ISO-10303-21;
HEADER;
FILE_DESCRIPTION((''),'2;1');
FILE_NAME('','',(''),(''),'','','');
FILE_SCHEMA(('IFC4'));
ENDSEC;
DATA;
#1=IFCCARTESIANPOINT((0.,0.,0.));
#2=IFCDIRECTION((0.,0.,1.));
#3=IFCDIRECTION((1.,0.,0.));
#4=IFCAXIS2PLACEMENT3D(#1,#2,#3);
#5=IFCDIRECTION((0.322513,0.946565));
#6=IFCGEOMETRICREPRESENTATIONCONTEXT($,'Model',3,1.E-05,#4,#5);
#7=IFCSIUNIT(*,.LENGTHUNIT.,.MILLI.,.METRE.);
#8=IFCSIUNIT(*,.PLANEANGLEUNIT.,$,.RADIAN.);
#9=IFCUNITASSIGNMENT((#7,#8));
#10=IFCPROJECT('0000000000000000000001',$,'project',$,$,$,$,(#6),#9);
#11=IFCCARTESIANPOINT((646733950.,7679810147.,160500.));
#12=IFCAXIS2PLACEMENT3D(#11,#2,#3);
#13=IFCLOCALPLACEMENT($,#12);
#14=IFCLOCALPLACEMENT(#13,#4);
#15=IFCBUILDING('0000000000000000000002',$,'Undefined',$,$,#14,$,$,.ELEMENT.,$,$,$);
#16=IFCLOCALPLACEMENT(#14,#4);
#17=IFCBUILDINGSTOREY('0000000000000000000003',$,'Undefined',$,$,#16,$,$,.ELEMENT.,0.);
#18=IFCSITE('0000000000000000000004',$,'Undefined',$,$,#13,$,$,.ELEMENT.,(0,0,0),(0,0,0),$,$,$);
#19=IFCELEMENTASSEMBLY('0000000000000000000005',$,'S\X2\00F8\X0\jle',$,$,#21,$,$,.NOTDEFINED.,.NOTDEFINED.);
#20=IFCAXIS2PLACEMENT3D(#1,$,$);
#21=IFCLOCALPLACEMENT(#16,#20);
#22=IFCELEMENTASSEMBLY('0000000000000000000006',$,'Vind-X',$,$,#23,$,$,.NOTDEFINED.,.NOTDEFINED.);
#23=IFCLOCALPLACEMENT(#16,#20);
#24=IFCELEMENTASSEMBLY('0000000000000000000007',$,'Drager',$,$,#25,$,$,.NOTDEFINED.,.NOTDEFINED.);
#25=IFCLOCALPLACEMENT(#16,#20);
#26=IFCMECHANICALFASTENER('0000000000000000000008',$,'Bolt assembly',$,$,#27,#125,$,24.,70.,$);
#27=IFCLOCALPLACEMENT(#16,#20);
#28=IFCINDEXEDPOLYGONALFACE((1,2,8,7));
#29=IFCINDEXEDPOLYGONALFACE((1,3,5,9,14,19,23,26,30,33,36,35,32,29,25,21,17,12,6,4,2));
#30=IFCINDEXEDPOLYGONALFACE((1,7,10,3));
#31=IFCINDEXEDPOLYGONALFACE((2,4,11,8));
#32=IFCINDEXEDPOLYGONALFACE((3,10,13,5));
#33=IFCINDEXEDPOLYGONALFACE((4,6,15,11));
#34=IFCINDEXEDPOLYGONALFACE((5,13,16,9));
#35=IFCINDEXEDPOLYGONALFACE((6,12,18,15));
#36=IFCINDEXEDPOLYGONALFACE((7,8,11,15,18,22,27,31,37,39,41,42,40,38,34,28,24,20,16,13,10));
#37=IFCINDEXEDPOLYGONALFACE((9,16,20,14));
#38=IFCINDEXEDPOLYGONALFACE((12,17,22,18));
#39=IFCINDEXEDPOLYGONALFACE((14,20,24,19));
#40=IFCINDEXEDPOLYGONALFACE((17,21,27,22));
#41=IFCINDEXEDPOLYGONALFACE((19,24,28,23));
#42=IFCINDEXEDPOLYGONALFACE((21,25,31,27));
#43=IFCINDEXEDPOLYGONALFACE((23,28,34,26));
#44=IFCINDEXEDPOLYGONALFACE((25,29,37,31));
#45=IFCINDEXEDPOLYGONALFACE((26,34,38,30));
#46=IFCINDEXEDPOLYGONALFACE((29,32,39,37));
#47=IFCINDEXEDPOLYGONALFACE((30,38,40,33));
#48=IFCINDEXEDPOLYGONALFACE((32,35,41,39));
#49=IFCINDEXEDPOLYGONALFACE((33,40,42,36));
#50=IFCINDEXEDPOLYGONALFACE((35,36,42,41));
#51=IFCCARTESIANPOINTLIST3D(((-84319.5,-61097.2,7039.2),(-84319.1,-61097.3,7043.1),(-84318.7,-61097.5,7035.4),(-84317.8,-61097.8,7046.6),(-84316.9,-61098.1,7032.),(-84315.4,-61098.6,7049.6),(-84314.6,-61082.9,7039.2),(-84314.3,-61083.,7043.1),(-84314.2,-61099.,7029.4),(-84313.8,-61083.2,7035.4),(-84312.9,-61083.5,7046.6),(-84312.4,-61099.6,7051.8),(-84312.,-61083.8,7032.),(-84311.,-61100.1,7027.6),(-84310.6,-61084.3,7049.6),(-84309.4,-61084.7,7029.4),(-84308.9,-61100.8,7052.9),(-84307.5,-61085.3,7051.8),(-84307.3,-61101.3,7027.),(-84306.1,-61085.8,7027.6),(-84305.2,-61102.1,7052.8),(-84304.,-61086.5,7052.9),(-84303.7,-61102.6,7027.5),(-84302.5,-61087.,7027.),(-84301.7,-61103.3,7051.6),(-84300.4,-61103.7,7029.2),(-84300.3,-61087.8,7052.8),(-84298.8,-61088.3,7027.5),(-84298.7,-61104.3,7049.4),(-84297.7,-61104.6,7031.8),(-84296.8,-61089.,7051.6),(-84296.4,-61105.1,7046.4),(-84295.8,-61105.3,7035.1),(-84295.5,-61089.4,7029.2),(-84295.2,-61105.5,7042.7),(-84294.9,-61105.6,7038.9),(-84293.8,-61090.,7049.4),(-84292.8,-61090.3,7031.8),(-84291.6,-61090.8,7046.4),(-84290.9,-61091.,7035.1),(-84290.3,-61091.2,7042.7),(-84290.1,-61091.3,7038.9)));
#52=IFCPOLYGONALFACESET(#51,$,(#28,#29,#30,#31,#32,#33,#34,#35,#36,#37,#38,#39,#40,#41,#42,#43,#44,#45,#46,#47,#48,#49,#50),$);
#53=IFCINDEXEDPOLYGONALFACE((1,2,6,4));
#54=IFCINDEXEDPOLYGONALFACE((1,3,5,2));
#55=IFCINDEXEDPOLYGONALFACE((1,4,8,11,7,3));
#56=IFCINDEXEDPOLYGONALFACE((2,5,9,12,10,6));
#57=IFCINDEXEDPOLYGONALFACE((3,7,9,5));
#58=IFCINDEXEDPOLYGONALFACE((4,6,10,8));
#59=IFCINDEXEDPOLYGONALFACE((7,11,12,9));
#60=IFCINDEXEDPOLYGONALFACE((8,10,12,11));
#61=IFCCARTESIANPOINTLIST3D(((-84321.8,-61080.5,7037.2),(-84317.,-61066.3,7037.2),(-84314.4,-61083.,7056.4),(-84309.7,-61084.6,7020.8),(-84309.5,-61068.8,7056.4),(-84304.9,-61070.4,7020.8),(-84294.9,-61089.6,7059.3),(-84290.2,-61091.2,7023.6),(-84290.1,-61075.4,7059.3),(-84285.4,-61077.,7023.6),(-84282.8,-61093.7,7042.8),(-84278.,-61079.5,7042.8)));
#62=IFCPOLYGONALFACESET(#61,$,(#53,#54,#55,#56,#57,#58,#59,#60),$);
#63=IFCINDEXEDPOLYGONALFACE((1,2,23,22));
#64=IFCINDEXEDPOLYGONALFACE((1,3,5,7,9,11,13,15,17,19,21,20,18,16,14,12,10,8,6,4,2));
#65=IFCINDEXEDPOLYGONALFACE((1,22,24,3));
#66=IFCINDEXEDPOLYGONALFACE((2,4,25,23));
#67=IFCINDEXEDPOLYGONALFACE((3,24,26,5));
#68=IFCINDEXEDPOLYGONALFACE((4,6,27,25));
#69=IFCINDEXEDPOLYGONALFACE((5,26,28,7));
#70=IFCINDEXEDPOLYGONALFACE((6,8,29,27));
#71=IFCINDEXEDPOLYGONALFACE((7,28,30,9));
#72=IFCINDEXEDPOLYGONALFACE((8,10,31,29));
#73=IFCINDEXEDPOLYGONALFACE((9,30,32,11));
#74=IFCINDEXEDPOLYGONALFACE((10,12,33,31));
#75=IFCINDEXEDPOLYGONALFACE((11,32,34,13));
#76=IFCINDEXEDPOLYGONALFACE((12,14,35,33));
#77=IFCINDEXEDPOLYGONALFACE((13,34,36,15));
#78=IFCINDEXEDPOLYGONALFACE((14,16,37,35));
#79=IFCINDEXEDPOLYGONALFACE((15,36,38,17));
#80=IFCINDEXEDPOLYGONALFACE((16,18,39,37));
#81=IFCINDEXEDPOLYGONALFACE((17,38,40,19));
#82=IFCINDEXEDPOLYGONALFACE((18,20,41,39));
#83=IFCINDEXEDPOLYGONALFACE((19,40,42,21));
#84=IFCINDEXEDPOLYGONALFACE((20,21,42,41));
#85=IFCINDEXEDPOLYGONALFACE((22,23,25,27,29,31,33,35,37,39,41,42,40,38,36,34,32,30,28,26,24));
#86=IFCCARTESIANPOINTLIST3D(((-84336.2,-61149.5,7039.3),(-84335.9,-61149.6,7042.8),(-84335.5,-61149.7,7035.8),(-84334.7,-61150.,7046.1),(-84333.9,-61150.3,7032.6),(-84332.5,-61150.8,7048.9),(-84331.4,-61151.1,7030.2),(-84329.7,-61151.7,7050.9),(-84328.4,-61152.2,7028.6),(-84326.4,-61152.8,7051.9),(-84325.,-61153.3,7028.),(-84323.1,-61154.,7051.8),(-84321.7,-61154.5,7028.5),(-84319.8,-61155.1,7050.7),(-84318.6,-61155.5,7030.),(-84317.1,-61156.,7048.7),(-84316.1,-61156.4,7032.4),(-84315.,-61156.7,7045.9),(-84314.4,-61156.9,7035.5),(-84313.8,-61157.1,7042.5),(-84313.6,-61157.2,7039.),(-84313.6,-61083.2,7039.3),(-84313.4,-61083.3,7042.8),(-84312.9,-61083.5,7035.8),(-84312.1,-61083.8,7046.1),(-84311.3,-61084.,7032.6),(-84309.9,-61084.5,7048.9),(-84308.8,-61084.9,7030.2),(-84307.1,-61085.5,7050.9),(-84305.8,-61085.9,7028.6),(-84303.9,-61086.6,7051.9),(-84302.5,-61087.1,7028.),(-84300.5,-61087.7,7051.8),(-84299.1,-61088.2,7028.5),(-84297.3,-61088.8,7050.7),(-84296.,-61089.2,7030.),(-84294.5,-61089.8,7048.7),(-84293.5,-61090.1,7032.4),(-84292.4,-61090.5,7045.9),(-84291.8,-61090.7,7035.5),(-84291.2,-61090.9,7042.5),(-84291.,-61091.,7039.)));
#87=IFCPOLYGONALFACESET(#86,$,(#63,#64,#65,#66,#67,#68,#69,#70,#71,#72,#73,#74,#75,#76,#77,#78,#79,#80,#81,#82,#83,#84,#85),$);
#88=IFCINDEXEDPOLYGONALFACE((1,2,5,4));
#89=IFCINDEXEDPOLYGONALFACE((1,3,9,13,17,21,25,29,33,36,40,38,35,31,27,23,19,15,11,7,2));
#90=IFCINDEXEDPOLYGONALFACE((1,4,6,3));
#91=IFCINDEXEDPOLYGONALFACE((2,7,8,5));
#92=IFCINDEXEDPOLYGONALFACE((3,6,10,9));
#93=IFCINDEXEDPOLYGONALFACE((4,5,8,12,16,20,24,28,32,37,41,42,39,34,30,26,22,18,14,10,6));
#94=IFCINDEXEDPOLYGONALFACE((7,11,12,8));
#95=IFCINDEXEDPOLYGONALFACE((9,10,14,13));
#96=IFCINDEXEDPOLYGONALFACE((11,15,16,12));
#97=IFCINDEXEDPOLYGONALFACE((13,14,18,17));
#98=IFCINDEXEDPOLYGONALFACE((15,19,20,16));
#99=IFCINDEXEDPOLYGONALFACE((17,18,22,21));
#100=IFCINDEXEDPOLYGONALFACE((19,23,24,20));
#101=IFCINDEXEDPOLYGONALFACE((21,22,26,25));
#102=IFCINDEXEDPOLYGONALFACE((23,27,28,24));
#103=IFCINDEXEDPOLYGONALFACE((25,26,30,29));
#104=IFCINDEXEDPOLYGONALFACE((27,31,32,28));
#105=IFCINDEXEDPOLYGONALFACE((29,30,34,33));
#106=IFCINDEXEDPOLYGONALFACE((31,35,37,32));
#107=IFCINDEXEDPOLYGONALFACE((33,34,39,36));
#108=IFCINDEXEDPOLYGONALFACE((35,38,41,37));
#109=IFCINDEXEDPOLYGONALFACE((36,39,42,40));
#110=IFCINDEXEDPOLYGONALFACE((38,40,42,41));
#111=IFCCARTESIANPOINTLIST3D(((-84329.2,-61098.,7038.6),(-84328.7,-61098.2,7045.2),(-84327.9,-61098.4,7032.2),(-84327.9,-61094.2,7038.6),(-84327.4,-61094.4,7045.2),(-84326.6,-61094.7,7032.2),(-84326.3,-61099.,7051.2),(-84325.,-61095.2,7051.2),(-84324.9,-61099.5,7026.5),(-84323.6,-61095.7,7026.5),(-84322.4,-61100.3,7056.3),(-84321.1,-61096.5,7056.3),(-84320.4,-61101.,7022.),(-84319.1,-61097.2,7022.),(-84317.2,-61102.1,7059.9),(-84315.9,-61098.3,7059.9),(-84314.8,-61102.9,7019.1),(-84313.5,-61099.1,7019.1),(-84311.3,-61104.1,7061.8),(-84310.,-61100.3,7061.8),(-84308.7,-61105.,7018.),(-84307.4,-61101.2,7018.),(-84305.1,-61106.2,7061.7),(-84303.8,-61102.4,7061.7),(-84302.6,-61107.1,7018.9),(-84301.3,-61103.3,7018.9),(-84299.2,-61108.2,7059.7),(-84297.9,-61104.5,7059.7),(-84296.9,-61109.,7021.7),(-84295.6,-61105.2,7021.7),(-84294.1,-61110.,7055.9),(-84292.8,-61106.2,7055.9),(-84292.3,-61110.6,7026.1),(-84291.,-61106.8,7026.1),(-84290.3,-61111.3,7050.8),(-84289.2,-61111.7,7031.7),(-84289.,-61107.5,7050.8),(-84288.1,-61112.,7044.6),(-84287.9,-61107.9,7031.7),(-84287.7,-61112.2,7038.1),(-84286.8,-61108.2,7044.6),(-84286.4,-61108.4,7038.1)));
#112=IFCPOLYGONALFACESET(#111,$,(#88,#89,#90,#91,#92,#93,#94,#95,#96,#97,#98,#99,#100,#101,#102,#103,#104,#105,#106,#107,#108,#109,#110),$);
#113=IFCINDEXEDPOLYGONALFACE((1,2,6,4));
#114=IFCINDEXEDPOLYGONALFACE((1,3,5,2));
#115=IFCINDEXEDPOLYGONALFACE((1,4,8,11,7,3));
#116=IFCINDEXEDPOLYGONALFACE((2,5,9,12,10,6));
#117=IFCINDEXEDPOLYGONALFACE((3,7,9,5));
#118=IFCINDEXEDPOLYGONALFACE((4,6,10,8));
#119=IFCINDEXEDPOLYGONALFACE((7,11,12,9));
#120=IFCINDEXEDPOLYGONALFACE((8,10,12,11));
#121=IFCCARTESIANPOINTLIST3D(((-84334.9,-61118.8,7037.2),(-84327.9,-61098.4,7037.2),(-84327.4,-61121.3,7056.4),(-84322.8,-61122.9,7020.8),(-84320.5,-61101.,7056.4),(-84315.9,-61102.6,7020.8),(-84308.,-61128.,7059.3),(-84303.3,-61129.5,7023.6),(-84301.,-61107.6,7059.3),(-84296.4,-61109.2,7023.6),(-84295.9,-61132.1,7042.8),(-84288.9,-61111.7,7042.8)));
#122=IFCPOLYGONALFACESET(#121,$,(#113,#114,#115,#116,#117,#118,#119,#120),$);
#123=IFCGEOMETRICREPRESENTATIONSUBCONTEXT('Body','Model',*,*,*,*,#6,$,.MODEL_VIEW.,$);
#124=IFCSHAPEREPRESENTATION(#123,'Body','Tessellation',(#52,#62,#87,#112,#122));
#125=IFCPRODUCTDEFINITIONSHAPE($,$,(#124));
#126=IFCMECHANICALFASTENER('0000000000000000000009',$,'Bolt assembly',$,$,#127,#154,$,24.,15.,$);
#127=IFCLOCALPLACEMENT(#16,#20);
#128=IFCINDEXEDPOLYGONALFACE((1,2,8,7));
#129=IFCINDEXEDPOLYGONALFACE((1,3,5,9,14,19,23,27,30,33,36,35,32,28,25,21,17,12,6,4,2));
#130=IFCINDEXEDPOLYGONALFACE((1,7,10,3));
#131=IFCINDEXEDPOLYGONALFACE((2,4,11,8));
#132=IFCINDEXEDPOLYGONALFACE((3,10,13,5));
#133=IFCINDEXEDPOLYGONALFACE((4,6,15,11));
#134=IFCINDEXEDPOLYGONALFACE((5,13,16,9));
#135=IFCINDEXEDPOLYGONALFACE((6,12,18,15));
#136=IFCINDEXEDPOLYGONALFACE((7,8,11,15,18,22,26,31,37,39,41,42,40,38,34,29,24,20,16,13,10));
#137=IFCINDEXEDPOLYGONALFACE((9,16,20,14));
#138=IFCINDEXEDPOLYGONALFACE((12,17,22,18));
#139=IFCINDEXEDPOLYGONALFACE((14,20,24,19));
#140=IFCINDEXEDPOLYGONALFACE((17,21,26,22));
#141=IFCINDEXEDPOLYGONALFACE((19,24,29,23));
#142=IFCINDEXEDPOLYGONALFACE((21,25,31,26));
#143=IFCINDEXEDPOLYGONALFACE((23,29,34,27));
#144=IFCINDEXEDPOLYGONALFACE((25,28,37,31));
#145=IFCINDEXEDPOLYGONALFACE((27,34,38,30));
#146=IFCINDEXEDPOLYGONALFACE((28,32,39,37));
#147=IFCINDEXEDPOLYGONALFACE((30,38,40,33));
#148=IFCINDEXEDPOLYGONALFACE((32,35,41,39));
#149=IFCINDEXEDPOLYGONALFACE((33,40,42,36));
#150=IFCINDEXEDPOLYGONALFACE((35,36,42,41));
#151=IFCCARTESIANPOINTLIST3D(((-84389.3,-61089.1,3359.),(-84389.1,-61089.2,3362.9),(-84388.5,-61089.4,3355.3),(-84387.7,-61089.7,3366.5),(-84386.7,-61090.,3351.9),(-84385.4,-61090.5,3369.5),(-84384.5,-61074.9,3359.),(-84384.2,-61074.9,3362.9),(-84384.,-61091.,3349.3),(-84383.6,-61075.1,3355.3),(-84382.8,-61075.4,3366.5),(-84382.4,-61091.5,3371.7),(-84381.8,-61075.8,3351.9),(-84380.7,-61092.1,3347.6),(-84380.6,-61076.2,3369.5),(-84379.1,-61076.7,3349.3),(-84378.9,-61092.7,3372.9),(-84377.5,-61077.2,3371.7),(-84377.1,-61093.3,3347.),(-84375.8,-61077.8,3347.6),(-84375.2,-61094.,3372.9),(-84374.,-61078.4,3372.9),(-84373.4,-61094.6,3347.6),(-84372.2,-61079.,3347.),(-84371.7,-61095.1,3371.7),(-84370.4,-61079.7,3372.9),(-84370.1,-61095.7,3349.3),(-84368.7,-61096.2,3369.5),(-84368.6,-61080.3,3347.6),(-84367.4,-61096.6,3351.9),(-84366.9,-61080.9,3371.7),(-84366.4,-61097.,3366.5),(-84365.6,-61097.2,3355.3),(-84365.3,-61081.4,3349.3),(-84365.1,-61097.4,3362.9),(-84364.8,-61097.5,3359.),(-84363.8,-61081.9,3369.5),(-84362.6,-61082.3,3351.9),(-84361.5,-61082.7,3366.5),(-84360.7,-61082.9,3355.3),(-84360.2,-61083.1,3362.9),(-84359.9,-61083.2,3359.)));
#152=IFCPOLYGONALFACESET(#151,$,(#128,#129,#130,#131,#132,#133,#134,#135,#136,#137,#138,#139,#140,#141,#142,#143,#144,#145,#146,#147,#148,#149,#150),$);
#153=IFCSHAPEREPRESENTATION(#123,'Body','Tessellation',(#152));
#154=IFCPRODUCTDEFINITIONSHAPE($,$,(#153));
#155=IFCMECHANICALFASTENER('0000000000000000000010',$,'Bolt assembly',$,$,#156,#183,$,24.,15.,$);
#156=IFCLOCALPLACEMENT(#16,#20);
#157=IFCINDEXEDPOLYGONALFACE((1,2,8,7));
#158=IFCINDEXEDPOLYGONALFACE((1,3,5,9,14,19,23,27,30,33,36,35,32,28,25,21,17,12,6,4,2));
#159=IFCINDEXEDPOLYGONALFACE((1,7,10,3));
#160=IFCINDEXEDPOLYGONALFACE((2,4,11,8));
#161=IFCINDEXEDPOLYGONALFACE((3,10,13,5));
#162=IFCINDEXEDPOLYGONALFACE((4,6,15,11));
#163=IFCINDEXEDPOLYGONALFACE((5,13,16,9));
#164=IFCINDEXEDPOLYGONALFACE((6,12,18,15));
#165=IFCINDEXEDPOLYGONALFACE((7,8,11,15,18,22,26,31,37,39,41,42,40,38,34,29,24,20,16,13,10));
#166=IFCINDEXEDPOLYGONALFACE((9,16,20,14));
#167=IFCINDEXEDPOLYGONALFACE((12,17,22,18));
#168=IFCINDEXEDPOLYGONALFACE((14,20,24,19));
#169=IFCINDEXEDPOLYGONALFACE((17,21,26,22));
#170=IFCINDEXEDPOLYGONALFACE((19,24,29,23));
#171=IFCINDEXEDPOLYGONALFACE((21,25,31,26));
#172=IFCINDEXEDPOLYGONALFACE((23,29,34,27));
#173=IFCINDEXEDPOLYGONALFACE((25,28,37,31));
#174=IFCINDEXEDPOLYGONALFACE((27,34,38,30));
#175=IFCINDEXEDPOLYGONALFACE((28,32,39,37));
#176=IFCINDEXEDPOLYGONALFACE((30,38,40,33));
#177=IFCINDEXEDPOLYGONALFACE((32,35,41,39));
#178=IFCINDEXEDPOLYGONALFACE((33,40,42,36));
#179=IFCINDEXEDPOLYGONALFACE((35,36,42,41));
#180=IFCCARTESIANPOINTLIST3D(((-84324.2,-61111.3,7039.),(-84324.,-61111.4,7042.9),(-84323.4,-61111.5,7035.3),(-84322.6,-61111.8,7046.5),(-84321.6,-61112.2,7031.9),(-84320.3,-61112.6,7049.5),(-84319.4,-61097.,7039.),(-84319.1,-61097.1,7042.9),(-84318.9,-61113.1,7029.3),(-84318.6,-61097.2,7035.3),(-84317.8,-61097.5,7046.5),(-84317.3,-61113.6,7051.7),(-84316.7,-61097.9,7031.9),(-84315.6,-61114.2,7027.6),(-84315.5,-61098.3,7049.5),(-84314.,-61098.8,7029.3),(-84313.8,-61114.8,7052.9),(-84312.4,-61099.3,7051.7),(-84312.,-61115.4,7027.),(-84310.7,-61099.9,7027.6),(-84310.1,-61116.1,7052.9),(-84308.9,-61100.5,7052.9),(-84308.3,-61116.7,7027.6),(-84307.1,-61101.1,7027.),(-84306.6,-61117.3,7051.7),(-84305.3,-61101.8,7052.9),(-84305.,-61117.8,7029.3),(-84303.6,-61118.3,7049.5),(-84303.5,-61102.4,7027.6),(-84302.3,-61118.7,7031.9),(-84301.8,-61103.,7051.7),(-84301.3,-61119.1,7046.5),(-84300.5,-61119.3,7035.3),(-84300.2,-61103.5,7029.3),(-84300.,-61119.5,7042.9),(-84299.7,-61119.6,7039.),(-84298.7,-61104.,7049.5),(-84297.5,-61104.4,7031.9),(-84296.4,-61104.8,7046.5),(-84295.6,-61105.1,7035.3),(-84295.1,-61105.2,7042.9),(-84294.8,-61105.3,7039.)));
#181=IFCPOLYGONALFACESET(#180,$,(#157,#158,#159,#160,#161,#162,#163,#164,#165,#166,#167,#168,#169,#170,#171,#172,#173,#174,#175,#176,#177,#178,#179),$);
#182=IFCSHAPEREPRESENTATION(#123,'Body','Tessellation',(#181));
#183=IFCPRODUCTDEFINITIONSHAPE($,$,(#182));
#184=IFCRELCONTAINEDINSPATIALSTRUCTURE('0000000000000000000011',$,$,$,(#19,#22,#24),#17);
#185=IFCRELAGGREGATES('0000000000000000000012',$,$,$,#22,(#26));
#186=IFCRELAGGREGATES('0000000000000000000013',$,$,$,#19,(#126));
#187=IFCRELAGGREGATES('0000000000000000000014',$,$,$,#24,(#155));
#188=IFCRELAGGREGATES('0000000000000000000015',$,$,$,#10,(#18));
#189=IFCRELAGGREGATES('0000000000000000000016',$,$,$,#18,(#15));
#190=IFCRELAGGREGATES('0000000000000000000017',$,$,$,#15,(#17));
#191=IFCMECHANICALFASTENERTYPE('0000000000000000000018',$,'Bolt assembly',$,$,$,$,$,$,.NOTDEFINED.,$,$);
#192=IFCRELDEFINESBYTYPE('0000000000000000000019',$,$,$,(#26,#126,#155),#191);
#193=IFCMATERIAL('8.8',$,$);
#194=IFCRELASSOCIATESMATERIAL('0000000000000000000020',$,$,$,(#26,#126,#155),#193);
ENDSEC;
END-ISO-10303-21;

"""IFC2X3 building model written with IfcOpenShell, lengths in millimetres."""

from ifc_helpers import new_model, si_unit, direction, frame, origin_with_axes, origin_2d_with_axis, place, context, subcontext, project, spatial, polyline, circle, outline, extrude, source, transform, mapped, material, type_object, element, aggregate, save


model = new_model("IFC2X3")

# Units and contexts
model_context = context("Model", 3, precision=1e-05, world=origin_with_axes(), true_north=direction((0.322513, 0.946565)))
body_context = subcontext(model_context, "Body", "Model", "MODEL_VIEW")
ifc_project = project(units=[si_unit("LENGTHUNIT", "METRE", prefix="MILLI"), si_unit("PLANEANGLEUNIT", "RADIAN")], contexts=[model_context])

# Site, building, storey
site_placement = place(None, frame((646733950.0, 7679810147.0, 160500.0), z_axis=(0.0, 0.0, 1.0), x_axis=(1.0, 0.0, 0.0)))
site = spatial("IfcSite", under=ifc_project, at=site_placement, Name="Undefined", CompositionType="ELEMENT", RefLatitude=(0, 0, 0), RefLongitude=(0, 0, 0))
building_placement = place(site_placement, origin_with_axes())
building = spatial("IfcBuilding", under=site, at=building_placement, Name="Undefined", CompositionType="ELEMENT")
storey_placement = place(building_placement, origin_with_axes())
storey = spatial("IfcBuildingStorey", under=building, at=storey_placement, Name="Undefined", CompositionType="ELEMENT", Elevation=0.0)

# Element assembly
assembly_1_placement = place(storey_placement, origin_with_axes())
assembly_1 = element("IfcElementAssembly", 1, at=assembly_1_placement, inside=storey, Name="Søjle", AssemblyPlace="NOTDEFINED", PredefinedType="NOTDEFINED")

# Element assembly
assembly_2_placement = place(storey_placement, origin_with_axes())
assembly_2 = element("IfcElementAssembly", 2, at=assembly_2_placement, inside=storey, Name="Vind-X", AssemblyPlace="NOTDEFINED", PredefinedType="NOTDEFINED")

# Element assembly
assembly_3_placement = place(storey_placement, origin_with_axes())
assembly_3 = element("IfcElementAssembly", 3, at=assembly_3_placement, inside=storey, Name="Drager", AssemblyPlace="NOTDEFINED", PredefinedType="NOTDEFINED")

# Mechanical fasteners
ifc_material_1 = material(Name="8.8")
mechanical_fastener_type = type_object("IfcMechanicalFastenerType", Name="Bolt assembly")
shared_shape_1 = source(origin_with_axes(), body_context, "Body", "SweptSolid", [
    extrude(circle(Radius=13.0, at=origin_2d_with_axis()), frame((0.0, 0.0, 0.0), z_axis=(0.0, 1.0, 0.0), x_axis=(1.0, 0.0, 0.0)), (0.0, 0.0, 1.0), 15.1),
    extrude(outline(polyline([(18.0, -10.4), (18.0, 10.4), (0.0, 20.8), (-18.0, 10.4), (-18.0, -10.4), (0.0, -20.8), (18.0, -10.4)])), frame((0.0, -15.0, 0.0), z_axis=(0.0, 1.0, 0.0), x_axis=(1.0, 0.0, 0.0)), (0.0, 0.0, 1.0), 15.0),
    extrude(circle(Radius=12.0, at=origin_2d_with_axis()), frame((0.0, 0.0, 0.0), z_axis=(0.0, 1.0, 0.0), x_axis=(1.0, 0.0, 0.0)), (0.0, 0.0, 1.0), 70.0),
    extrude(circle(Radius=22.0, at=origin_2d_with_axis()), frame((0.0, 15.0, 0.0), z_axis=(0.0, 1.0, 0.0), x_axis=(1.0, 0.0, 0.0)), (0.0, 0.0, 1.0), 4.0),
    extrude(outline(polyline([(18.0, -10.4), (18.0, 10.4), (0.0, 20.8), (-18.0, 10.4), (-18.0, -10.4), (0.0, -20.8), (18.0, -10.4)])), frame((0.0, 19.0, 0.0), z_axis=(0.0, 1.0, 0.0), x_axis=(1.0, 0.0, 0.0)), (0.0, 0.0, 1.0), 21.5),
])
mechanical_fastener_1_placement = place(assembly_2_placement, frame((-84302.3, -61087.1, 7040.0), z_axis=(-0.580575, 0.197813, 0.789812), x_axis=(-0.747608, 0.254725, -0.613349)))
mechanical_fastener_1 = element("IfcMechanicalFastener", 4, at=mechanical_fastener_1_placement, type_object=mechanical_fastener_type, material=ifc_material_1, Name="Bolt assembly", NominalDiameter=24.0, NominalLength=70.0, context=body_context, shape_type="MappedRepresentation", body=[
    mapped(shared_shape_1, transform((0.0, 0.0, 0.0))),
])
aggregate(assembly_2, [mechanical_fastener_1])
shared_shape_2 = source(origin_with_axes(), body_context, "Body", "SweptSolid", [
    extrude(circle(Radius=13.0, at=origin_2d_with_axis()), frame((0.0, -7.5, 0.0), z_axis=(0.0, 1.0, 0.0), x_axis=(1.0, 0.0, 0.0)), (0.0, 0.0, 1.0), 15.1),
])
mechanical_fastener_2_placement = place(assembly_1_placement, frame((-84374.6, -61086.2, 3360.0), z_axis=(0.946565, -0.322513, 0.0), x_axis=(0.0, 0.0, -1.0)))
mechanical_fastener_2 = element("IfcMechanicalFastener", 5, at=mechanical_fastener_2_placement, type_object=mechanical_fastener_type, material=ifc_material_1, Name="Bolt assembly", NominalDiameter=24.0, NominalLength=15.0, context=body_context, shape_type="MappedRepresentation", body=[
    mapped(shared_shape_2, transform((0.0, 0.0, 0.0))),
])
aggregate(assembly_1, [mechanical_fastener_2])
shared_shape_3 = source(origin_with_axes(), body_context, "Body", "SweptSolid", [
    extrude(circle(Radius=13.0, at=origin_2d_with_axis()), frame((0.0, -7.4, 0.0), z_axis=(0.0, 1.0, 0.0), x_axis=(1.0, 0.0, 0.0)), (0.0, 0.0, 1.0), 15.1),
])
mechanical_fastener_3_placement = place(assembly_3_placement, frame((-84309.6, -61108.4, 7040.0), z_axis=(0.946565, -0.322513, 0.0), x_axis=(0.0, 0.0, -1.0)))
mechanical_fastener_3 = element("IfcMechanicalFastener", 6, at=mechanical_fastener_3_placement, type_object=mechanical_fastener_type, material=ifc_material_1, Name="Bolt assembly", NominalDiameter=24.0, NominalLength=15.0, context=body_context, shape_type="MappedRepresentation", body=[
    mapped(shared_shape_3, transform((0.0, 0.0, 0.0))),
])
aggregate(assembly_3, [mechanical_fastener_3])

save(model, "model.ifc")
